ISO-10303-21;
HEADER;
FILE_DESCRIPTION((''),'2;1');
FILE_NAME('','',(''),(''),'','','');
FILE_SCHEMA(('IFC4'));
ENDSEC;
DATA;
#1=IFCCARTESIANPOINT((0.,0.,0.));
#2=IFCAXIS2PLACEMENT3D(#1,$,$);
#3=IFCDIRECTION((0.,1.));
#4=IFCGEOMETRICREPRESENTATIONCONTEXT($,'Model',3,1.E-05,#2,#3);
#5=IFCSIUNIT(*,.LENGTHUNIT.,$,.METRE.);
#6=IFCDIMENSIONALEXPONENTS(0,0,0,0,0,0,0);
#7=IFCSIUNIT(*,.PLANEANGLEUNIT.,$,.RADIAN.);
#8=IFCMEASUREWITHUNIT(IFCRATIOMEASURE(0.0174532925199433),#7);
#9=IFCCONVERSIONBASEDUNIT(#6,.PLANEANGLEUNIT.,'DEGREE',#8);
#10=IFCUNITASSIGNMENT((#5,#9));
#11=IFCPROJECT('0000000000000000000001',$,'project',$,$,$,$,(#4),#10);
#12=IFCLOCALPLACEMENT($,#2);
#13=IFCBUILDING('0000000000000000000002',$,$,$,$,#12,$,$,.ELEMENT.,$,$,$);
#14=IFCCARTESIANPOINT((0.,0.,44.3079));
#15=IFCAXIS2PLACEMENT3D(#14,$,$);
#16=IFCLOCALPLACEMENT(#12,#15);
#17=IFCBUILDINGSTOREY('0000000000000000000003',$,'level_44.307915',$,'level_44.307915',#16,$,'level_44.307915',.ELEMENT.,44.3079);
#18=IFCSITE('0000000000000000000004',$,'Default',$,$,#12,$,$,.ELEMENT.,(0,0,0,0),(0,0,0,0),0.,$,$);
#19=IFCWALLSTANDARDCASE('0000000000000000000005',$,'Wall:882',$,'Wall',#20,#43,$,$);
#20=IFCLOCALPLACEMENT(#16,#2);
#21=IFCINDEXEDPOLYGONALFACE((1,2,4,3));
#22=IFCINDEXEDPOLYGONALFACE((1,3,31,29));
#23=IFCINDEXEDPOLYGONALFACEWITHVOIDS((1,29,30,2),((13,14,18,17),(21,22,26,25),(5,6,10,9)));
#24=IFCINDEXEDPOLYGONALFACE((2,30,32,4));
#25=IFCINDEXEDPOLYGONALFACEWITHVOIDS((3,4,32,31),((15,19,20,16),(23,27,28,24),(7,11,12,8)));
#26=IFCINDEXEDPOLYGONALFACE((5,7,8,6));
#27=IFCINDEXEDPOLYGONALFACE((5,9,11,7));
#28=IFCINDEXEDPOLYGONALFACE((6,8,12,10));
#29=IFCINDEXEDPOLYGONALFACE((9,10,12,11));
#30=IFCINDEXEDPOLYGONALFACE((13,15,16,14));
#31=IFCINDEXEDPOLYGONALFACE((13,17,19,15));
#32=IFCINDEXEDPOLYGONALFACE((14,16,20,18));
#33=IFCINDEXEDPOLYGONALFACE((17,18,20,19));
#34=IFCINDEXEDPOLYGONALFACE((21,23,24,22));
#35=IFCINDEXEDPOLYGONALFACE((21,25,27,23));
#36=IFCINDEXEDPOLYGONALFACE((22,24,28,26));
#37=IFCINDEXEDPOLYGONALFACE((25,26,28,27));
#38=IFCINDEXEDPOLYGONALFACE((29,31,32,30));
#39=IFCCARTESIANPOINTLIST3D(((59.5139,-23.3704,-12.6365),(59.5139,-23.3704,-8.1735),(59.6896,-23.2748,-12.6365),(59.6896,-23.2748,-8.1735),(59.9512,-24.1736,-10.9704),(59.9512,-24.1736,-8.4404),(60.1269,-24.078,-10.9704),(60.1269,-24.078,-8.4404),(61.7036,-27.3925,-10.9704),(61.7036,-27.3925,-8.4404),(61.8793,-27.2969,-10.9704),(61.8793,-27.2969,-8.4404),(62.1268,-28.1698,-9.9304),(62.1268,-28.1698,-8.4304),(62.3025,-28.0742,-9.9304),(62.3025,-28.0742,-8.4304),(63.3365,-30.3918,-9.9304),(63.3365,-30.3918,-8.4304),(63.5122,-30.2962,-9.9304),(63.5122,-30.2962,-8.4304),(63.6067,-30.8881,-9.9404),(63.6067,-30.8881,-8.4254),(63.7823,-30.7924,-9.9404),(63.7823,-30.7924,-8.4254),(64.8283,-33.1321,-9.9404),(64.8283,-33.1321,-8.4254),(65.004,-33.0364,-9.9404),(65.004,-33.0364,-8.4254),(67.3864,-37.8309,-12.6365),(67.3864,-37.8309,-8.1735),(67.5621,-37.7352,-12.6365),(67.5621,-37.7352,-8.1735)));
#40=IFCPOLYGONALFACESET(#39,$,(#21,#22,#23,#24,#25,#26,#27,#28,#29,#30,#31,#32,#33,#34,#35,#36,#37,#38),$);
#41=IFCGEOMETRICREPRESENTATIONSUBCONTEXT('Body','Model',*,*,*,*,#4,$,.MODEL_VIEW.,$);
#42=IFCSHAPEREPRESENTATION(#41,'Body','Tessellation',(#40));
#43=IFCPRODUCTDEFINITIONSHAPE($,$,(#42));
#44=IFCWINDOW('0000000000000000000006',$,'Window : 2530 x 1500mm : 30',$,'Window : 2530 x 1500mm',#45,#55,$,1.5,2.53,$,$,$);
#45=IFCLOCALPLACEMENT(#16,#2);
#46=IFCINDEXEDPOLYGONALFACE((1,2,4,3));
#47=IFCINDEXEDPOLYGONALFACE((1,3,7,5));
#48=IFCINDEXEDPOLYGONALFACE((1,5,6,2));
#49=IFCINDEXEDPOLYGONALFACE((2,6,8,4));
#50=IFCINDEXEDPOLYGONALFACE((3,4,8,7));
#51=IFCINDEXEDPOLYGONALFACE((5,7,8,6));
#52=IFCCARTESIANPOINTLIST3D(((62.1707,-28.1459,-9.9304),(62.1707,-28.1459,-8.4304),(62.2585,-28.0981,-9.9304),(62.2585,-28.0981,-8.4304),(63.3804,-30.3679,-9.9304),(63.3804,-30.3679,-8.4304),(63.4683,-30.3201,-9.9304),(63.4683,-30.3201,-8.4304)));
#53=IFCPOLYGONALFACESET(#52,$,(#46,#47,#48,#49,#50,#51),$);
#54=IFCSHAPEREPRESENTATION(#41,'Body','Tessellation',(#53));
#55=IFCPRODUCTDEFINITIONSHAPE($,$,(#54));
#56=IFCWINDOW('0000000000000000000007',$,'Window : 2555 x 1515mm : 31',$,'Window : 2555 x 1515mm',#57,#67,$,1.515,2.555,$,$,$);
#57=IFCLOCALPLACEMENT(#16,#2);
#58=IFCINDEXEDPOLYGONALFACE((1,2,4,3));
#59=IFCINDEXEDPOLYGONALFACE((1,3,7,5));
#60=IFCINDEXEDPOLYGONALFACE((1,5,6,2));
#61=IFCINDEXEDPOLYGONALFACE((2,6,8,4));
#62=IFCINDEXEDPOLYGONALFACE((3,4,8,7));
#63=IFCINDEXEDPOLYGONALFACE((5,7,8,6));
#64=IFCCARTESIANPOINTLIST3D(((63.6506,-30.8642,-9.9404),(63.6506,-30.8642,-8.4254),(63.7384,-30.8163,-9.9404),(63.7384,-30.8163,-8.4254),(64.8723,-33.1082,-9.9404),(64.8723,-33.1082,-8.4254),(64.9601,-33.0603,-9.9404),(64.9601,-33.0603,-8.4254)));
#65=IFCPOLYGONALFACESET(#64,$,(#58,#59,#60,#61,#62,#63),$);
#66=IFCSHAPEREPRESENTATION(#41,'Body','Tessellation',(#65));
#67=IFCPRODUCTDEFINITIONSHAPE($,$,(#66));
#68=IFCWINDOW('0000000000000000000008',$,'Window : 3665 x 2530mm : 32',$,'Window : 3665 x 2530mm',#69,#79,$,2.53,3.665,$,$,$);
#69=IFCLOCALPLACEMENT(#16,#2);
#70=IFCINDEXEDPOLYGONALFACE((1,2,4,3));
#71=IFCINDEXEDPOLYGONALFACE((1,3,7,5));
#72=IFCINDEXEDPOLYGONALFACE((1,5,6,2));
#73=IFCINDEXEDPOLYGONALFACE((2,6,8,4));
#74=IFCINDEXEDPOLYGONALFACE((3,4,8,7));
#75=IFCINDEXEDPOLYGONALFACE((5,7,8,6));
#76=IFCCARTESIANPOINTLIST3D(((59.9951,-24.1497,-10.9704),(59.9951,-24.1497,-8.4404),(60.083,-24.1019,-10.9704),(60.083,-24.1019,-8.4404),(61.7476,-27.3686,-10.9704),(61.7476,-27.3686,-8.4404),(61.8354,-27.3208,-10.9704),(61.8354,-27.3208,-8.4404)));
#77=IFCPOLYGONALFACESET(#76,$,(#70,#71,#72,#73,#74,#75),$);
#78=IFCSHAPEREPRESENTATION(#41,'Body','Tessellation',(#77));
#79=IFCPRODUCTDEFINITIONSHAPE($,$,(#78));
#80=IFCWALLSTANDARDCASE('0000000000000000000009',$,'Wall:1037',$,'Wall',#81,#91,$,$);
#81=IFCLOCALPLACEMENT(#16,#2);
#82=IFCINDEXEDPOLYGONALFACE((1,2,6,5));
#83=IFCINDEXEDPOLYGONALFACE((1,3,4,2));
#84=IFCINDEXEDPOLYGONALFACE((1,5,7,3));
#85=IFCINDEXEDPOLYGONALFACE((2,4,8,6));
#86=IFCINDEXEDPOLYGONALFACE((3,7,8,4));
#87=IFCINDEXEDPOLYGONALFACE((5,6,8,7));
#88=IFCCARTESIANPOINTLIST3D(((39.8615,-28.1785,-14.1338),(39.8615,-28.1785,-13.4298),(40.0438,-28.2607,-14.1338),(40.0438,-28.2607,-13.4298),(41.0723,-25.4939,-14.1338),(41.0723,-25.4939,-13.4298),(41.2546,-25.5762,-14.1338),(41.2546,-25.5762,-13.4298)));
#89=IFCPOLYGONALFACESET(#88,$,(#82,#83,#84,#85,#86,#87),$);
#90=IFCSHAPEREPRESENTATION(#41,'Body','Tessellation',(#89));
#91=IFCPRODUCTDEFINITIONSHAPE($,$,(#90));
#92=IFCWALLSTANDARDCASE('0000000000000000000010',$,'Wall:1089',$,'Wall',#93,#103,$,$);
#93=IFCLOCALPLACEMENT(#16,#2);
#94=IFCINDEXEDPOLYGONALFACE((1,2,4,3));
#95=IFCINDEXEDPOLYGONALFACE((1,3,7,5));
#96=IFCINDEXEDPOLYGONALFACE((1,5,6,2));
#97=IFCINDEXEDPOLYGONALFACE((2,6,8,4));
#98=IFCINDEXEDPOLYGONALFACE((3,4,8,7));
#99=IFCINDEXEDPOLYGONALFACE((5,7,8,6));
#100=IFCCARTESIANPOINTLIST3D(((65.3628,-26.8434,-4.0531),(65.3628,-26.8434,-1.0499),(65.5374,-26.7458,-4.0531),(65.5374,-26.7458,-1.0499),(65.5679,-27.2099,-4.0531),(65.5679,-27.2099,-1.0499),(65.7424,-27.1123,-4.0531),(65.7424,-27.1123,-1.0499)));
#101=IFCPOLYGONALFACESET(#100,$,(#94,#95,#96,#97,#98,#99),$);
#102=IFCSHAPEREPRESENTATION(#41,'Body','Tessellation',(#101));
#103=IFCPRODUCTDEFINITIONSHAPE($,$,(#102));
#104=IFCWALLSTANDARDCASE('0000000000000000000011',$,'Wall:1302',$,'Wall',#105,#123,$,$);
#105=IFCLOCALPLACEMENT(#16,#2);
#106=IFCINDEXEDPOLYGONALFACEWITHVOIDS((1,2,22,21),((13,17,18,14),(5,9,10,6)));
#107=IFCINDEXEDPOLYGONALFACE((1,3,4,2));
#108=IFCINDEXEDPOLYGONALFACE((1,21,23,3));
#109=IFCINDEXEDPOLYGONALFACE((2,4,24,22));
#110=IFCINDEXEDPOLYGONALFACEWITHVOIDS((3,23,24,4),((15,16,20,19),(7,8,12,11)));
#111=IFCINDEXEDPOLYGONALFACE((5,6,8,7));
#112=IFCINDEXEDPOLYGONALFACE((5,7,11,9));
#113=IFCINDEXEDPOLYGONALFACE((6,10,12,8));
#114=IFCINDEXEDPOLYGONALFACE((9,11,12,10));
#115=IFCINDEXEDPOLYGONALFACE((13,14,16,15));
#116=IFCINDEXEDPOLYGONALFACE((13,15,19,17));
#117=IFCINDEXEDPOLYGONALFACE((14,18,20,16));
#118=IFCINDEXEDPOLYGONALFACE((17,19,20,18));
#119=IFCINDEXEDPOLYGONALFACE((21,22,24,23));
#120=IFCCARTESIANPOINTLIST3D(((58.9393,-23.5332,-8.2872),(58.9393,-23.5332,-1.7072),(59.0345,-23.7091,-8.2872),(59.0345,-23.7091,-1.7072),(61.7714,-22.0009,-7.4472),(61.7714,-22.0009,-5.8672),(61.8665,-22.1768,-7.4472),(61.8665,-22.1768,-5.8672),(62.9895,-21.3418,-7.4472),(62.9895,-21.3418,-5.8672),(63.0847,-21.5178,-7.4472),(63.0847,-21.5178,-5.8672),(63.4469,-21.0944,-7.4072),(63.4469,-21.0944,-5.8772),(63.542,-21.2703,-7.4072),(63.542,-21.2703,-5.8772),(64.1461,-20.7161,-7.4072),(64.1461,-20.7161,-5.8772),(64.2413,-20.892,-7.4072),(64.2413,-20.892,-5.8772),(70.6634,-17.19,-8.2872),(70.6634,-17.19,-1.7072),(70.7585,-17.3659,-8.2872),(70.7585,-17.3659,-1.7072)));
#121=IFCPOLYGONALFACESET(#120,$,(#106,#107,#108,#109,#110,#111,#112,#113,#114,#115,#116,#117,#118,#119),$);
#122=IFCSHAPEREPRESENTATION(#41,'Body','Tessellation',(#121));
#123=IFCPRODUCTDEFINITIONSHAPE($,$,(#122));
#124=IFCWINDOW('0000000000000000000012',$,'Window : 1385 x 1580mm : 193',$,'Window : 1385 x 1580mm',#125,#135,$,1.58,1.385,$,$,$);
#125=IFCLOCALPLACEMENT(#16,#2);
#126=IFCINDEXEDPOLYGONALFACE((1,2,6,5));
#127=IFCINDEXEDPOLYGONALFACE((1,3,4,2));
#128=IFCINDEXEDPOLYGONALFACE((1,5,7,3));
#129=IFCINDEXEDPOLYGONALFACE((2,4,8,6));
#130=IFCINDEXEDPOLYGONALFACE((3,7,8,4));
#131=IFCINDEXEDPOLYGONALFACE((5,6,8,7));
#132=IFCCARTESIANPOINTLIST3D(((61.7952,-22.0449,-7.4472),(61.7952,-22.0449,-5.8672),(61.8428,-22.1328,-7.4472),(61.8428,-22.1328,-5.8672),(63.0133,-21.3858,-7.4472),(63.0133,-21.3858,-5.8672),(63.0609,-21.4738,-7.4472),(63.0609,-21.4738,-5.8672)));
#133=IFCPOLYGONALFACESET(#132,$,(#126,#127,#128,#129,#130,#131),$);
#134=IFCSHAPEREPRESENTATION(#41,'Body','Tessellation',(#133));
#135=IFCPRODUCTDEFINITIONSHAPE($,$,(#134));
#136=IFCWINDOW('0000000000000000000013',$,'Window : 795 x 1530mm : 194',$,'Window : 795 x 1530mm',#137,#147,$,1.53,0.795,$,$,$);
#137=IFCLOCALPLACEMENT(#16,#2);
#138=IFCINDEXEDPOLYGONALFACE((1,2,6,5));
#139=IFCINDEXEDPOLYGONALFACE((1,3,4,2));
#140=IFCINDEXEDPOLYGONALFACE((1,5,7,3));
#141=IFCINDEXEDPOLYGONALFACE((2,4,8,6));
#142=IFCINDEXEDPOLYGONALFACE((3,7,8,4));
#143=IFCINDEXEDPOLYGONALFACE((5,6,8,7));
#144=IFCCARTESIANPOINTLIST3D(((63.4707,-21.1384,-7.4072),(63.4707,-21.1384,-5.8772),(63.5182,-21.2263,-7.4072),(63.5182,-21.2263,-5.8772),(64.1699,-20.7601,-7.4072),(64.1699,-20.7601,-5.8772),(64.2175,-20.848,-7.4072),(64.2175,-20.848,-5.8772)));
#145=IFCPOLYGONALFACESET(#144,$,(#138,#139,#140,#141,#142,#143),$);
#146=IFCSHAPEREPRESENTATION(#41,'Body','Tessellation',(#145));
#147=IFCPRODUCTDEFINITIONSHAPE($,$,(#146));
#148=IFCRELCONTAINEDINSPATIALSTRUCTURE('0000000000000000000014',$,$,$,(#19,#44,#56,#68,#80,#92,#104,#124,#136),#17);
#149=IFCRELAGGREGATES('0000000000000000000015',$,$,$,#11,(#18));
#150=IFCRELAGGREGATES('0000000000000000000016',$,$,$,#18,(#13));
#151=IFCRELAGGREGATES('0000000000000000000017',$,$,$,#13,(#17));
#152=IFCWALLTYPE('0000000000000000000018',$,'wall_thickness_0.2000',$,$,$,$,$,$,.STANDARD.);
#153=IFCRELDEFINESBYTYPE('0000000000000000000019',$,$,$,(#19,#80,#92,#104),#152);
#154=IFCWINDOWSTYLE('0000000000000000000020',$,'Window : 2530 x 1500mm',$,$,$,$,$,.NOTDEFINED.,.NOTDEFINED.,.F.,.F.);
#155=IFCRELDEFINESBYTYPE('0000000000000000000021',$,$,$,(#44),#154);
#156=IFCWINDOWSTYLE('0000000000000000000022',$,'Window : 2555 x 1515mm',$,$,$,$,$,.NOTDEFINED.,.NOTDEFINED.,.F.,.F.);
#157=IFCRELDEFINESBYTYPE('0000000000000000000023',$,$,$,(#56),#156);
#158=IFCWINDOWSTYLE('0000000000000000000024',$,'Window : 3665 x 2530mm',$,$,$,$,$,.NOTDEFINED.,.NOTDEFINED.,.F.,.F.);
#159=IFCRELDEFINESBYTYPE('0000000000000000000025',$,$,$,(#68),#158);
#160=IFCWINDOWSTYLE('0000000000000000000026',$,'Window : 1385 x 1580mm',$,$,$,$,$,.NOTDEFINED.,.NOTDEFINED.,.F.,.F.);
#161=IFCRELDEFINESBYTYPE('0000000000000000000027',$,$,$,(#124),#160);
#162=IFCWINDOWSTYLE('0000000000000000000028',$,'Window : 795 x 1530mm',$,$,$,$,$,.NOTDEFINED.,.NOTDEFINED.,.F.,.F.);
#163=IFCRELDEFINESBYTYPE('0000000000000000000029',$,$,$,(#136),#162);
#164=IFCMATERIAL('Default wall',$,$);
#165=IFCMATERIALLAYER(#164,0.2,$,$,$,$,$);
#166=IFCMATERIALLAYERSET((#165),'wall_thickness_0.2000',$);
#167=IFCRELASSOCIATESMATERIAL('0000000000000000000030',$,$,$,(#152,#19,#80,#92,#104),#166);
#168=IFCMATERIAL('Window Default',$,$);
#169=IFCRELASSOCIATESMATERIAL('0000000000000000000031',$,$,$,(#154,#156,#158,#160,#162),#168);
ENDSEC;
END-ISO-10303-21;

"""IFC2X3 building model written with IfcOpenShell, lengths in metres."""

from ifc_helpers import new_model, entity, si_unit, converted_unit, direction, frame, frame_2d, origin, origin_2d_with_axis, place, context, subcontext, project, spatial, polyline, rectangle, outline, extrude, source, transform, mapped, material, layer, layer_set, layer_usage, type_object, type_shapes, element, fill, save


model = new_model("IFC2X3")

# Units and contexts
model_context = context("Model", 3, precision=1e-05, world=origin(), true_north=direction((0.0, 1.0)))
body_context = subcontext(model_context, "Body", "Model", "MODEL_VIEW")
ifc_project = project(units=[si_unit("LENGTHUNIT", "METRE"), converted_unit("PLANEANGLEUNIT", "DEGREE", entity("IfcRatioMeasure", 0.0174532925199433), si_unit("PLANEANGLEUNIT", "RADIAN"), dimensions=[0, 0, 0, 0, 0, 0, 0])], contexts=[model_context])

# Site, building, storey
placement_1 = place(None, origin())
site = spatial("IfcSite", under=ifc_project, at=placement_1, Name="Default", CompositionType="ELEMENT", RefLatitude=(0, 0, 0, 0), RefLongitude=(0, 0, 0, 0), RefElevation=0.0)
building = spatial("IfcBuilding", under=site, at=placement_1, CompositionType="ELEMENT")
storey_placement = place(placement_1, frame((0.0, 0.0, 44.3079)))
storey = spatial("IfcBuildingStorey", under=building, at=storey_placement, Name="level_44.307915", ObjectType="level_44.307915", LongName="level_44.307915", CompositionType="ELEMENT", Elevation=44.3079)

# Shared definitions
ifc_material_1 = material(Name="Default wall")
ifc_layer = layer(ifc_material_1, 0.2)
ifc_layer_set = layer_set([ifc_layer], Name="wall_thickness_0.2000")
ifc_layer_usage = layer_usage(ifc_layer_set, "AXIS2", "POSITIVE", -0.1)
wall_type = type_object("IfcWallType", Name="wall_thickness_0.2000", PredefinedType="STANDARD", material=ifc_layer_set)

# Shared definitions
ifc_material_2 = material(Name="Window Default")

# Wall, openings, windows
placement_2 = place(placement_1, frame((0.0, 0.0, 31.6714)))
wall_1_placement = place(placement_2, frame((59.6018, -23.3226, 0.0), z_axis=(0.0, 0.0, 1.0), x_axis=(0.478148, -0.878279, 0.0)))
wall_1 = element("IfcWallStandardCase", 1, at=wall_1_placement, inside=storey, type_object=wall_type, material=ifc_layer_usage, Name="Wall:882", ObjectType="Wall", context=body_context, shape_type="SweptSolid", body=[
    extrude(outline(polyline([(16.4645, -0.1), (16.4645, 0.1), (0.0, 0.1), (0.0, -0.1), (16.4645, -0.1)])), origin(), (0.0, 0.0, 1.0), 4.463),
])
opening_1_placement = place(wall_1_placement, frame((5.4645, -0.1, 2.7061)))
opening_1 = element("IfcOpeningElement", 2, at=opening_1_placement, cuts=wall_1, ObjectType="Opening", context=body_context, shape_type="SweptSolid", body=[
    extrude(rectangle(XDim=2.53, YDim=1.5, at=frame_2d((0.75, 1.265), x_axis=(0.0, 1.0))), frame((0.0, 0.0, 0.0), z_axis=(0.0, 1.0, 0.0), x_axis=(0.0, 0.0, 1.0)), (0.0, 0.0, 1.0), 0.2),
])
opening_2_placement = place(wall_1_placement, frame((8.5595, -0.1, 2.6961)))
opening_2 = element("IfcOpeningElement", 3, at=opening_2_placement, cuts=wall_1, ObjectType="Opening", context=body_context, shape_type="SweptSolid", body=[
    extrude(rectangle(XDim=2.555, YDim=1.515, at=frame_2d((0.7575, 1.2775), x_axis=(0.0, 1.0))), frame((0.0, 0.0, 0.0), z_axis=(0.0, 1.0, 0.0), x_axis=(0.0, 0.0, 1.0)), (0.0, 0.0, 1.0), 0.2),
])
opening_3_placement = place(wall_1_placement, frame((0.9145, -0.1, 1.6661)))
opening_3 = element("IfcOpeningElement", 4, at=opening_3_placement, cuts=wall_1, ObjectType="Opening", context=body_context, shape_type="SweptSolid", body=[
    extrude(rectangle(XDim=3.665, YDim=2.53, at=frame_2d((1.265, 1.8325), x_axis=(0.0, 1.0))), frame((0.0, 0.0, 0.0), z_axis=(0.0, 1.0, 0.0), x_axis=(0.0, 0.0, 1.0)), (0.0, 0.0, 1.0), 0.2),
])
window_style_1 = type_object("IfcWindowStyle", Name="Window : 2530 x 1500mm", ConstructionType="NOTDEFINED", OperationType="NOTDEFINED", ParameterTakesPrecedence=False, Sizeable=False, material=ifc_material_2)
shared_shape_1 = source(origin(), body_context, "Body", "SweptSolid", [
    extrude(rectangle(XDim=0.1, YDim=2.53, at=origin_2d_with_axis()), frame((1.265, 0.1, 0.0), z_axis=(0.0, 0.0, 1.0), x_axis=(0.0, 1.0, 0.0)), (0.0, 0.0, 1.0), 1.5),
])
type_shapes(window_style_1, [shared_shape_1])
window_1_placement = place(opening_1_placement, origin())
window_1 = element("IfcWindow", 5, at=window_1_placement, inside=storey, type_object=window_style_1, Name="Window : 2530 x 1500mm : 30", ObjectType="Window : 2530 x 1500mm", OverallHeight=1.5, OverallWidth=2.53, context=body_context, shape_type="MappedRepresentation", body=[
    mapped(shared_shape_1, transform((0.0, 0.0, 0.0), scale=1.0)),
])
fill(opening_1, window_1)
window_style_2 = type_object("IfcWindowStyle", Name="Window : 2555 x 1515mm", ConstructionType="NOTDEFINED", OperationType="NOTDEFINED", ParameterTakesPrecedence=False, Sizeable=False, material=ifc_material_2)
shared_shape_2 = source(origin(), body_context, "Body", "SweptSolid", [
    extrude(rectangle(XDim=0.1, YDim=2.555, at=origin_2d_with_axis()), frame((1.2775, 0.1, 0.0), z_axis=(0.0, 0.0, 1.0), x_axis=(0.0, 1.0, 0.0)), (0.0, 0.0, 1.0), 1.515),
])
type_shapes(window_style_2, [shared_shape_2])
window_2_placement = place(opening_2_placement, origin())
window_2 = element("IfcWindow", 6, at=window_2_placement, inside=storey, type_object=window_style_2, Name="Window : 2555 x 1515mm : 31", ObjectType="Window : 2555 x 1515mm", OverallHeight=1.515, OverallWidth=2.555, context=body_context, shape_type="MappedRepresentation", body=[
    mapped(shared_shape_2, transform((0.0, 0.0, 0.0), scale=1.0)),
])
fill(opening_2, window_2)
window_style_3 = type_object("IfcWindowStyle", Name="Window : 3665 x 2530mm", ConstructionType="NOTDEFINED", OperationType="NOTDEFINED", ParameterTakesPrecedence=False, Sizeable=False, material=ifc_material_2)
shared_shape_3 = source(origin(), body_context, "Body", "SweptSolid", [
    extrude(rectangle(XDim=0.1, YDim=3.665, at=origin_2d_with_axis()), frame((1.8325, 0.1, 0.0), z_axis=(0.0, 0.0, 1.0), x_axis=(0.0, 1.0, 0.0)), (0.0, 0.0, 1.0), 2.53),
])
type_shapes(window_style_3, [shared_shape_3])
window_3_placement = place(opening_3_placement, origin())
window_3 = element("IfcWindow", 7, at=window_3_placement, inside=storey, type_object=window_style_3, Name="Window : 3665 x 2530mm : 32", ObjectType="Window : 3665 x 2530mm", OverallHeight=2.53, OverallWidth=3.665, context=body_context, shape_type="MappedRepresentation", body=[
    mapped(shared_shape_3, transform((0.0, 0.0, 0.0), scale=1.0)),
])
fill(opening_3, window_3)

# Walls
placement_3 = place(placement_1, frame((0.0, 0.0, 30.1741)))
wall_2_placement = place(placement_3, frame((39.9527, -28.2196, 0.0), z_axis=(0.0, 0.0, 1.0), x_axis=(0.411138, 0.911573, 0.0)))
element("IfcWallStandardCase", 8, at=wall_2_placement, inside=storey, type_object=wall_type, material=ifc_layer_usage, Name="Wall:1037", ObjectType="Wall", context=body_context, shape_type="SweptSolid", body=[
    extrude(outline(polyline([(2.945, -0.1), (2.945, 0.1), (0.0, 0.1), (0.0, -0.1), (2.945, -0.1)])), origin(), (0.0, 0.0, 1.0), 0.704),
])
placement_4 = place(placement_1, frame((0.0, 0.0, 40.2548)))
wall_3_placement = place(placement_4, frame((65.4501, -26.7946, 0.0), z_axis=(0.0, 0.0, 1.0), x_axis=(0.488206, -0.872728, 0.0)))
element("IfcWallStandardCase", 9, at=wall_3_placement, inside=storey, type_object=wall_type, material=ifc_layer_usage, Name="Wall:1089", ObjectType="Wall", context=body_context, shape_type="SweptSolid", body=[
    extrude(outline(polyline([(0.42, -0.1), (0.42, 0.1), (0.0, 0.1), (0.0, -0.1), (0.42, -0.1)])), origin(), (0.0, 0.0, 1.0), 3.0032),
])

# Wall, openings, windows
placement_5 = place(placement_1, frame((0.0, 0.0, 36.0207)))
wall_4_placement = place(placement_5, frame((58.9869, -23.6211, 0.0), z_axis=(0.0, 0.0, 1.0), x_axis=(0.879524, 0.475854, 0.0)))
wall_4 = element("IfcWallStandardCase", 10, at=wall_4_placement, inside=storey, type_object=wall_type, material=ifc_layer_usage, Name="Wall:1302", ObjectType="Wall", context=body_context, shape_type="SweptSolid", body=[
    extrude(outline(polyline([(13.33, -0.1), (13.33, 0.1), (0.0, 0.1), (0.0, -0.1), (13.33, -0.1)])), origin(), (0.0, 0.0, 1.0), 6.58),
])
opening_4_placement = place(wall_4_placement, frame((3.22, -0.1, 0.84)))
opening_4 = element("IfcOpeningElement", 11, at=opening_4_placement, cuts=wall_4, ObjectType="Opening", context=body_context, shape_type="SweptSolid", body=[
    extrude(rectangle(XDim=1.385, YDim=1.58, at=frame_2d((0.79, 0.6925), x_axis=(0.0, 1.0))), frame((0.0, 0.0, 0.0), z_axis=(0.0, 1.0, 0.0), x_axis=(0.0, 0.0, 1.0)), (0.0, 0.0, 1.0), 0.2),
])
opening_5_placement = place(wall_4_placement, frame((5.125, -0.1, 0.88)))
opening_5 = element("IfcOpeningElement", 12, at=opening_5_placement, cuts=wall_4, ObjectType="Opening", context=body_context, shape_type="SweptSolid", body=[
    extrude(rectangle(XDim=0.795, YDim=1.53, at=frame_2d((0.765, 0.3975), x_axis=(0.0, 1.0))), frame((0.0, 0.0, 0.0), z_axis=(0.0, 1.0, 0.0), x_axis=(0.0, 0.0, 1.0)), (0.0, 0.0, 1.0), 0.2),
])
window_style_4 = type_object("IfcWindowStyle", Name="Window : 1385 x 1580mm", ConstructionType="NOTDEFINED", OperationType="NOTDEFINED", ParameterTakesPrecedence=False, Sizeable=False, material=ifc_material_2)
shared_shape_4 = source(origin(), body_context, "Body", "SweptSolid", [
    extrude(rectangle(XDim=0.1, YDim=1.385, at=origin_2d_with_axis()), frame((0.6925, 0.1, 0.0), z_axis=(0.0, 0.0, 1.0), x_axis=(0.0, 1.0, 0.0)), (0.0, 0.0, 1.0), 1.58),
])
type_shapes(window_style_4, [shared_shape_4])
window_4_placement = place(opening_4_placement, origin())
window_4 = element("IfcWindow", 13, at=window_4_placement, inside=storey, type_object=window_style_4, Name="Window : 1385 x 1580mm : 193", ObjectType="Window : 1385 x 1580mm", OverallHeight=1.58, OverallWidth=1.385, context=body_context, shape_type="MappedRepresentation", body=[
    mapped(shared_shape_4, transform((0.0, 0.0, 0.0), scale=1.0)),
])
fill(opening_4, window_4)
window_style_5 = type_object("IfcWindowStyle", Name="Window : 795 x 1530mm", ConstructionType="NOTDEFINED", OperationType="NOTDEFINED", ParameterTakesPrecedence=False, Sizeable=False, material=ifc_material_2)
shared_shape_5 = source(origin(), body_context, "Body", "SweptSolid", [
    extrude(rectangle(XDim=0.1, YDim=0.795, at=origin_2d_with_axis()), frame((0.3975, 0.1, 0.0), z_axis=(0.0, 0.0, 1.0), x_axis=(0.0, 1.0, 0.0)), (0.0, 0.0, 1.0), 1.53),
])
type_shapes(window_style_5, [shared_shape_5])
window_5_placement = place(opening_5_placement, origin())
window_5 = element("IfcWindow", 14, at=window_5_placement, inside=storey, type_object=window_style_5, Name="Window : 795 x 1530mm : 194", ObjectType="Window : 795 x 1530mm", OverallHeight=1.53, OverallWidth=0.795, context=body_context, shape_type="MappedRepresentation", body=[
    mapped(shared_shape_5, transform((0.0, 0.0, 0.0), scale=1.0)),
])
fill(opening_5, window_5)

save(model, "model.ifc")
